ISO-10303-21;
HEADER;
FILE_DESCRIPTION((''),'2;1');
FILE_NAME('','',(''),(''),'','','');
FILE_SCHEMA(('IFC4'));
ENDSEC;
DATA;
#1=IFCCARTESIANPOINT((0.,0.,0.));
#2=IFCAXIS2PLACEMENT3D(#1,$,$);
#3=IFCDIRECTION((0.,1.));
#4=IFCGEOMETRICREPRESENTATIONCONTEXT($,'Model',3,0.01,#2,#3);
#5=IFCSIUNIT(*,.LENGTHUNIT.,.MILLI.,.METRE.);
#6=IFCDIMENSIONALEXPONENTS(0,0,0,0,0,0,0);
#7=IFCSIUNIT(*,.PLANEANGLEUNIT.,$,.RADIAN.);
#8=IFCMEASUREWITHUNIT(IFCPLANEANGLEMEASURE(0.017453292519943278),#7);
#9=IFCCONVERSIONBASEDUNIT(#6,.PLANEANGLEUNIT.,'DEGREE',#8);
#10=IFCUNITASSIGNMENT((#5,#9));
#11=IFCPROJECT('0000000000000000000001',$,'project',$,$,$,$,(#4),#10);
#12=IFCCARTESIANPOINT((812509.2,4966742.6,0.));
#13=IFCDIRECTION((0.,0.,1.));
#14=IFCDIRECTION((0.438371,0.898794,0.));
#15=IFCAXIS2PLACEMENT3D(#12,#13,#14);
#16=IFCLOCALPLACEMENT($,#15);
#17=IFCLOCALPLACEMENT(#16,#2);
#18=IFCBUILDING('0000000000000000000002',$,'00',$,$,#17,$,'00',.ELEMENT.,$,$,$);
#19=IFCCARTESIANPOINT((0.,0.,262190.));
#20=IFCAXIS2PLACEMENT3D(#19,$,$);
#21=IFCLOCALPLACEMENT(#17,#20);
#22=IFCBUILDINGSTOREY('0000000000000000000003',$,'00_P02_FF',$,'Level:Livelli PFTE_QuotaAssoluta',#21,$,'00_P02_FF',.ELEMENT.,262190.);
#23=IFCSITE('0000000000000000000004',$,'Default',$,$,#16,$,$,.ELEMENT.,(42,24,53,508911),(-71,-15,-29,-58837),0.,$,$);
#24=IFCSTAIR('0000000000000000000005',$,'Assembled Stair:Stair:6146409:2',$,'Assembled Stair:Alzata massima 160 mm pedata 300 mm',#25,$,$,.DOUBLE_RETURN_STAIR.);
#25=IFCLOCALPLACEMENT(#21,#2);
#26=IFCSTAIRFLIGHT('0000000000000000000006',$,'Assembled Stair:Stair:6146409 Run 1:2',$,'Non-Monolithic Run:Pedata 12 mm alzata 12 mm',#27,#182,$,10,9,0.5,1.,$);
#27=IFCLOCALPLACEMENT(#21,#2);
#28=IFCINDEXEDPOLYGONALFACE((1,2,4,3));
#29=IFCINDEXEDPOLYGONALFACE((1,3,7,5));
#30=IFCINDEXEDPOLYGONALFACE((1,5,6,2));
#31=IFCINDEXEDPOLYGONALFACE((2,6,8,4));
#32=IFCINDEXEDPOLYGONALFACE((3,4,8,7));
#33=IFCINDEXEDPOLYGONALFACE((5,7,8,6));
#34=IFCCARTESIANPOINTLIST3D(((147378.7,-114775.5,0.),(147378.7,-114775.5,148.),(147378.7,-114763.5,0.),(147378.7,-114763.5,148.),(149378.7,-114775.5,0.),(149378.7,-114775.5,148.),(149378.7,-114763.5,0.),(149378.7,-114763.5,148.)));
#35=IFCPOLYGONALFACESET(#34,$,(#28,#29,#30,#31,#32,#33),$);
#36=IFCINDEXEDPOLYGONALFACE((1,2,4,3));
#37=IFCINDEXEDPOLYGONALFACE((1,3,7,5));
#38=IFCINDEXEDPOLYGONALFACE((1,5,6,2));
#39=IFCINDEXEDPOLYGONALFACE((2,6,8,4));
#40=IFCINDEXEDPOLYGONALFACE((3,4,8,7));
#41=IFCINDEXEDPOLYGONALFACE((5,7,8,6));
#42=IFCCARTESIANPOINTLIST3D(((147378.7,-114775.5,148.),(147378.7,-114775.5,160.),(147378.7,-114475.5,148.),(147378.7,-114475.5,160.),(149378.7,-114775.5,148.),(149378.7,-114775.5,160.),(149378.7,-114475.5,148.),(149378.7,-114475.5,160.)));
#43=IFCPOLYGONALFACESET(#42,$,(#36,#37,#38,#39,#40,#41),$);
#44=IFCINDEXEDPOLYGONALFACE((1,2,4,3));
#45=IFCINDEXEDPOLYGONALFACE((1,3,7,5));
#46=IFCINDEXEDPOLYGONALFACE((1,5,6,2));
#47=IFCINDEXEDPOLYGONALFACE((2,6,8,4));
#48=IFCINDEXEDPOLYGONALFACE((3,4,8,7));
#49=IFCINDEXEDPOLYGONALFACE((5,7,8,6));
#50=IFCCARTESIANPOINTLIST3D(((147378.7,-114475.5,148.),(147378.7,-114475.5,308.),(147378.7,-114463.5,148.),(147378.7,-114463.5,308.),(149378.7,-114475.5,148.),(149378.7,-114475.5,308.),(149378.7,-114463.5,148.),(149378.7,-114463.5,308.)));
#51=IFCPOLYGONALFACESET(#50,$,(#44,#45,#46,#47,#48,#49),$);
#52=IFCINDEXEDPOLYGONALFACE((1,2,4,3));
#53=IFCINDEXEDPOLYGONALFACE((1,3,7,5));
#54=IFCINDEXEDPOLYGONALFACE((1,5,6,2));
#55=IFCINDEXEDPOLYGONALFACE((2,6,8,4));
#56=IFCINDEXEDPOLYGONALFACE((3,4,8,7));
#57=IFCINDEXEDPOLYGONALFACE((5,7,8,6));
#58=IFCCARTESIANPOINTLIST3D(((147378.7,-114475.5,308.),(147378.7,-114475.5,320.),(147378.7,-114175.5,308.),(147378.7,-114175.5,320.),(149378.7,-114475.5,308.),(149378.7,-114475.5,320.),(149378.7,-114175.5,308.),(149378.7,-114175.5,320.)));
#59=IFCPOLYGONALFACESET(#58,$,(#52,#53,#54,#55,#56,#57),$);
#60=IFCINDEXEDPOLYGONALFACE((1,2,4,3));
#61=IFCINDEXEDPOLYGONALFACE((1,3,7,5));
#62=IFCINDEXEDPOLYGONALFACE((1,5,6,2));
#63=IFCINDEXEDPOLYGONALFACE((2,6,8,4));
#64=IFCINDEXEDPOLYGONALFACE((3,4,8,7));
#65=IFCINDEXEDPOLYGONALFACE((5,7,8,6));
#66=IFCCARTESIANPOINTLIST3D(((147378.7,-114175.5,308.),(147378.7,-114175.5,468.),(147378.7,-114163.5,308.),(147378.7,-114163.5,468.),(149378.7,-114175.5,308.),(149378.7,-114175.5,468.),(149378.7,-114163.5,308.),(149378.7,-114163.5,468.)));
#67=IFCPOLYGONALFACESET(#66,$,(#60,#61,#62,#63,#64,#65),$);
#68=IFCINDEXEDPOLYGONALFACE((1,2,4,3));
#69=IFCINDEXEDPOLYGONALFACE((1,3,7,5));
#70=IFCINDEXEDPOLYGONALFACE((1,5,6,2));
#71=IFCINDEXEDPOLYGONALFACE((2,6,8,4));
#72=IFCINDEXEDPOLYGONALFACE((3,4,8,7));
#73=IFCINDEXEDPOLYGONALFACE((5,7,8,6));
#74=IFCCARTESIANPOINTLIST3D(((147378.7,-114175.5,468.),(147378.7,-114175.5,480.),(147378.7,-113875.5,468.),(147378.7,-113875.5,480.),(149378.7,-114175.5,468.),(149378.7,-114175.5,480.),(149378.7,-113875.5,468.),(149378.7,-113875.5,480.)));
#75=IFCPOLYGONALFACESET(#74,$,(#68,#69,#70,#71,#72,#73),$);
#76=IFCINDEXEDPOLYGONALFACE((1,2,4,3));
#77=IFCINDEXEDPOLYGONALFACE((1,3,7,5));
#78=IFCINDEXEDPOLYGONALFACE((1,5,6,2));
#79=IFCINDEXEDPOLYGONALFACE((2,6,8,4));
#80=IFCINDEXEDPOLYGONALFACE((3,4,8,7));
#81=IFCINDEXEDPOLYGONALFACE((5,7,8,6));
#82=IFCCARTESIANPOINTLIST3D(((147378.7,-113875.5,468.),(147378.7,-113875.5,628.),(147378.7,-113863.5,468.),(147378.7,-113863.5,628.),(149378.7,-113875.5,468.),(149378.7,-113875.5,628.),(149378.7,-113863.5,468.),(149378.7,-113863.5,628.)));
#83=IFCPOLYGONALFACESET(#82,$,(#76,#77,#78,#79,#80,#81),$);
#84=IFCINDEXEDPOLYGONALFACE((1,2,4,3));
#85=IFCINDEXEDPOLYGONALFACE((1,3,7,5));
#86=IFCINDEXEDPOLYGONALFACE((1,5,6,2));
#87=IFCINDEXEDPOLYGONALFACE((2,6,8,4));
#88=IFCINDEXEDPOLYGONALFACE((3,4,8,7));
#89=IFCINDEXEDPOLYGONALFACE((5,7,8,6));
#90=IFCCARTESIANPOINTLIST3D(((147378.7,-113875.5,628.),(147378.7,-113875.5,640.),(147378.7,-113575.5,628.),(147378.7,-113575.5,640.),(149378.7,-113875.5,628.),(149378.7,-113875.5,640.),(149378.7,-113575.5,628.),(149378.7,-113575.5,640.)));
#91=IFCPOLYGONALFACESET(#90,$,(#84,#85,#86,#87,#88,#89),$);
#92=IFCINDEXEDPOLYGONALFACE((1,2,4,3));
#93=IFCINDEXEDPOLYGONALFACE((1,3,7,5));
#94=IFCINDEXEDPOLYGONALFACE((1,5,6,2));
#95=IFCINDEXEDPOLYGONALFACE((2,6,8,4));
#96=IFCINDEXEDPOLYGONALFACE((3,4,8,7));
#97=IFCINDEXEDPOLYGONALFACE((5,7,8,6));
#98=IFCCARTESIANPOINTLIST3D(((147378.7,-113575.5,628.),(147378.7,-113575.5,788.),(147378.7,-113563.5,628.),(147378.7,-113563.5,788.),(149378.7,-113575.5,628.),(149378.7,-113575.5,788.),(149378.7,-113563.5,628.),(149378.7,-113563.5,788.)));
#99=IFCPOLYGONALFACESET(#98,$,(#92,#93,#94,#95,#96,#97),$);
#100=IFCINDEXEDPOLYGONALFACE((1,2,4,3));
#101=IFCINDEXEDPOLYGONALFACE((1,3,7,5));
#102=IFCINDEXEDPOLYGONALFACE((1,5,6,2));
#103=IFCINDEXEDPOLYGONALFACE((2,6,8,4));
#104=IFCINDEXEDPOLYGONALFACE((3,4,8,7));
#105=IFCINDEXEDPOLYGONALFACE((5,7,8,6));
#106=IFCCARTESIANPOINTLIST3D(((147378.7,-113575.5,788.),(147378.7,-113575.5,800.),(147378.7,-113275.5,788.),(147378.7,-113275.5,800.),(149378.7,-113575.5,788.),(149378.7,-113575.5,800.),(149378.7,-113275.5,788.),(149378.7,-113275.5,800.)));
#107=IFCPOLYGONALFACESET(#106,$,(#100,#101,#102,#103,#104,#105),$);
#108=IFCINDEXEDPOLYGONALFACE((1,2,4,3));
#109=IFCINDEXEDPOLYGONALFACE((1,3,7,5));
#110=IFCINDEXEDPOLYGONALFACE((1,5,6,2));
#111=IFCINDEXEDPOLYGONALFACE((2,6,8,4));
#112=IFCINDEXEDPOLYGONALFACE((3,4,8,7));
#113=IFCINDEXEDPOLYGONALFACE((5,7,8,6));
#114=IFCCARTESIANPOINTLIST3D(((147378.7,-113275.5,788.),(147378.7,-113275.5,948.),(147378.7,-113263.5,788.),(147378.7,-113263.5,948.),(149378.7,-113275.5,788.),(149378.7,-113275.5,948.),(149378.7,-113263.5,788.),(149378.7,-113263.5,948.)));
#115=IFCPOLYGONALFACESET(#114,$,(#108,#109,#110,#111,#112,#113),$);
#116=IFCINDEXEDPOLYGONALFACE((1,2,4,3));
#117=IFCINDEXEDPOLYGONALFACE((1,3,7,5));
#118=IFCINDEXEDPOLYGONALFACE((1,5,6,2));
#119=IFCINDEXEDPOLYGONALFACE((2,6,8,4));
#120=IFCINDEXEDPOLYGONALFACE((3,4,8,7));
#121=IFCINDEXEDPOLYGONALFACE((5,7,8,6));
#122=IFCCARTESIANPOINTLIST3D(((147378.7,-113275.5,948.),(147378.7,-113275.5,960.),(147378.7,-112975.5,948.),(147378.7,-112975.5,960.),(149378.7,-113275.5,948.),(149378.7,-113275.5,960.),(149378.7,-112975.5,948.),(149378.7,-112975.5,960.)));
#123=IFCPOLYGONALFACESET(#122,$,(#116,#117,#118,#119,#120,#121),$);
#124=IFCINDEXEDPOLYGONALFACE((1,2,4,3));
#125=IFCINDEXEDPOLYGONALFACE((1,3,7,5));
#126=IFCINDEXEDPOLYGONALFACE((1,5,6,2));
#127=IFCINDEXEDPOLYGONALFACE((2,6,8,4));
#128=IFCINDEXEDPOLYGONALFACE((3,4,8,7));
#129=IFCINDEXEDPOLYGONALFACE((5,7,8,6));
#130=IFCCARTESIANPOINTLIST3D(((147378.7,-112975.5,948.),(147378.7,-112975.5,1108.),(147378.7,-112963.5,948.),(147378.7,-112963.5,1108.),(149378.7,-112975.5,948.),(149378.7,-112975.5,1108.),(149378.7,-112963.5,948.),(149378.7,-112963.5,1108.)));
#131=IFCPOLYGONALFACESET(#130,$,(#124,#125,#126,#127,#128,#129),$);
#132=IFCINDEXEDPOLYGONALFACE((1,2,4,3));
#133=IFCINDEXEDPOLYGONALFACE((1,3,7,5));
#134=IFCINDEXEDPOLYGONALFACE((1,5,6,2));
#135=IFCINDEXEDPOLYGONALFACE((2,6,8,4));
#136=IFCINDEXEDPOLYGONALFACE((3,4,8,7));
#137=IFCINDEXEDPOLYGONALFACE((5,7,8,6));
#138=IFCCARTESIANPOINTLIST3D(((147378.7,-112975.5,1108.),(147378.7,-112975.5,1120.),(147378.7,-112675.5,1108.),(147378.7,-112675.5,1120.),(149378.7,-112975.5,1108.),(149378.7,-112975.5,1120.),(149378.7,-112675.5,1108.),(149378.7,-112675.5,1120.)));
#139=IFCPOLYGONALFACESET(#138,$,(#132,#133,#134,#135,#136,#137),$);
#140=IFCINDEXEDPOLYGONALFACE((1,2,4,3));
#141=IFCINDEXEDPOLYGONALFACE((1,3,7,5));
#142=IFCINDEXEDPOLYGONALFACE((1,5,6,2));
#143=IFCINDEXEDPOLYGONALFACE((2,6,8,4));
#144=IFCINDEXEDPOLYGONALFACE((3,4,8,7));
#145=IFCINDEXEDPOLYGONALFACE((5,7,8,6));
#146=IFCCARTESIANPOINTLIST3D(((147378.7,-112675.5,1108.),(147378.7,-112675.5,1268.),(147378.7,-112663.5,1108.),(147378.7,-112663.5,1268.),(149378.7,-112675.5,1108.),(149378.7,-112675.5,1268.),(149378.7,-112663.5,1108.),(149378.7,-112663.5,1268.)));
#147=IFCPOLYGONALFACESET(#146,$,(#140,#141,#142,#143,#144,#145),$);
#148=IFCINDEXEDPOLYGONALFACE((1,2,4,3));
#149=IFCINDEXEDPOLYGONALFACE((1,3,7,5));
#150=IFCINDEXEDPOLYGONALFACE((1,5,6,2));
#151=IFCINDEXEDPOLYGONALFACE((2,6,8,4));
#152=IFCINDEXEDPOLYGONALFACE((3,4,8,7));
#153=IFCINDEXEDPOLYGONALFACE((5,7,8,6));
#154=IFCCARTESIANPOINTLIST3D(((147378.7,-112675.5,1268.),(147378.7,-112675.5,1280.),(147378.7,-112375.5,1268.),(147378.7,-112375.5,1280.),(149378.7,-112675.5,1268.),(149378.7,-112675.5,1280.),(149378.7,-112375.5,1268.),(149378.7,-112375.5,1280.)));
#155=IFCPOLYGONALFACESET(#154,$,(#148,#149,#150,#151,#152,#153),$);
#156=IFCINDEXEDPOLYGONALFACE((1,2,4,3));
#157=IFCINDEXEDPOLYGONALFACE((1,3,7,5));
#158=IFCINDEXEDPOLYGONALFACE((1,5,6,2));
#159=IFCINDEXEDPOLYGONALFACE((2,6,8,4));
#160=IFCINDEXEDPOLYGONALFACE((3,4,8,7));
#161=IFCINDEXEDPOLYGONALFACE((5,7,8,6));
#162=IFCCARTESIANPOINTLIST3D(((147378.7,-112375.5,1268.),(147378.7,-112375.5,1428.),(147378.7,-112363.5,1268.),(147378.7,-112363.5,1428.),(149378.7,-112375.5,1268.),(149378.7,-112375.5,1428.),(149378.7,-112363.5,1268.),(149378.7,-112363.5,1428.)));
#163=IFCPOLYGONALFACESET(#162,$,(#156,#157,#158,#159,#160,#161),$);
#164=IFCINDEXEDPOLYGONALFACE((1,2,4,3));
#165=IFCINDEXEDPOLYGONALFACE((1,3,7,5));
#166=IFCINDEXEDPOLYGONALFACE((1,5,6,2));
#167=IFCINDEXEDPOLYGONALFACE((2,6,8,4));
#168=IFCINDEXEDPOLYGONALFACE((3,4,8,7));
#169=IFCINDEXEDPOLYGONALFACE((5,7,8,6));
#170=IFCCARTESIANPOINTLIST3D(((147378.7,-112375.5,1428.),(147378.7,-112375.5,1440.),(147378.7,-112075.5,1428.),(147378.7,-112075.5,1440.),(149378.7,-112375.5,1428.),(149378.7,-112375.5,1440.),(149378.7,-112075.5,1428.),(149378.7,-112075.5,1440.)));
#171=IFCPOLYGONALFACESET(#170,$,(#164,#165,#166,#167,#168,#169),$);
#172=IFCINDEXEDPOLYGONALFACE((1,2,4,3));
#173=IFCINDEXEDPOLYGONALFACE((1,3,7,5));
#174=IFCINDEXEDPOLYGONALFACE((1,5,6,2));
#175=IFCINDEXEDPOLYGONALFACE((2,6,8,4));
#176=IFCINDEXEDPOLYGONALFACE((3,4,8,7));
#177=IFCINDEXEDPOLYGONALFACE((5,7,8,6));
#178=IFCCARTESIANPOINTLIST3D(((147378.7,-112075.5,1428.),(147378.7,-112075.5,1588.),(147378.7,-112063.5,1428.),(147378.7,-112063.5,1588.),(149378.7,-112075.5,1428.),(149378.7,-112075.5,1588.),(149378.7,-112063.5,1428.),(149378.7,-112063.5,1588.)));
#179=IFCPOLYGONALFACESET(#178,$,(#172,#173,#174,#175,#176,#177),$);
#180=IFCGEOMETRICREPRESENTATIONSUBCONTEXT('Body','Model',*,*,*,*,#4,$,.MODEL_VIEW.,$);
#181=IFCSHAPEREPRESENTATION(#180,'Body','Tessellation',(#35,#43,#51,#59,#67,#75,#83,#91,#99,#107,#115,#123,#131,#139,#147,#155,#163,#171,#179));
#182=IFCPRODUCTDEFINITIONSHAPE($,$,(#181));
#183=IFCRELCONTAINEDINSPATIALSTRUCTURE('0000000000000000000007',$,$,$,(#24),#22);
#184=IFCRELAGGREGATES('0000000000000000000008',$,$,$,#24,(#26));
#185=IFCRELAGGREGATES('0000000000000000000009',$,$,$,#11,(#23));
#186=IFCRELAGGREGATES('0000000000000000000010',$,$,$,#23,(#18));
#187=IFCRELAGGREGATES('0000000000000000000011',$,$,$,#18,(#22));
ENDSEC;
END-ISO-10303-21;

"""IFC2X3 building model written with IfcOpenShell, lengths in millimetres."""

from ifc_helpers import new_model, entity, si_unit, converted_unit, direction, frame, frame_2d, origin, origin_2d_with_axis, place, context, subcontext, project, spatial, rectangle, extrude, element, aggregate, save


model = new_model("IFC2X3")

# Units and contexts
model_context = context("Model", 3, precision=0.01, world=origin(), true_north=direction((0.0, 1.0)))
body_context = subcontext(model_context, "Body", "Model", "MODEL_VIEW")
ifc_project = project(units=[si_unit("LENGTHUNIT", "METRE", prefix="MILLI"), converted_unit("PLANEANGLEUNIT", "DEGREE", entity("IfcPlaneAngleMeasure", 0.017453292519943278), si_unit("PLANEANGLEUNIT", "RADIAN"), dimensions=[0, 0, 0, 0, 0, 0, 0])], contexts=[model_context])

# Site, building, storey
site_placement = place(None, frame((812509.2, 4966742.6, 0.0), z_axis=(0.0, 0.0, 1.0), x_axis=(0.438371, 0.898794, 0.0)))
site = spatial("IfcSite", under=ifc_project, at=site_placement, Name="Default", CompositionType="ELEMENT", RefLatitude=(42, 24, 53, 508911), RefLongitude=(-71, -15, -29, -58837), RefElevation=0.0)
building_placement = place(site_placement, origin())
building = spatial("IfcBuilding", under=site, at=building_placement, Name="00", LongName="00", CompositionType="ELEMENT")
storey_placement = place(building_placement, frame((0.0, 0.0, 262190.0)))
storey = spatial("IfcBuildingStorey", under=building, at=storey_placement, Name="00_P02_FF", ObjectType="Level:Livelli PFTE_QuotaAssoluta", LongName="00_P02_FF", CompositionType="ELEMENT", Elevation=262190.0)

# Stair
stair_1_placement = place(storey_placement, origin())
stair_1 = element("IfcStair", 1, at=stair_1_placement, inside=storey, Name="Assembled Stair:Stair:6146409:2", ObjectType="Assembled Stair:Alzata massima 160 mm pedata 300 mm", ShapeType="DOUBLE_RETURN_STAIR")

# Stair flight
stair_flight_1_placement = place(stair_1_placement, origin())
stair_flight_1 = element("IfcStairFlight", 2, at=stair_flight_1_placement, Name="Assembled Stair:Stair:6146409 Run 1:2", ObjectType="Non-Monolithic Run:Pedata 12 mm alzata 12 mm", NumberOfRiser=10, NumberOfTreads=9, RiserHeight=0.5, TreadLength=1.0, context=body_context, shape_type="SweptSolid", body=[
    extrude(rectangle(XDim=2000.0, YDim=12.0, at=origin_2d_with_axis()), frame((148378.7, -114769.5, 0.0), z_axis=(0.0, 0.0, 1.0), x_axis=(-1.0, 0.0, 0.0)), (0.0, 0.0, 1.0), 148.0),
    extrude(rectangle(XDim=300.0, YDim=2000.0, at=frame_2d((0.0, 0.0), x_axis=(1.0, 0.0))), frame((148378.7, -114625.5, 148.0), z_axis=(0.0, 0.0, 1.0), x_axis=(0.0, -1.0, 0.0)), (0.0, 0.0, 1.0), 12.0),
    extrude(rectangle(XDim=2000.0, YDim=12.0, at=frame_2d((0.0, 0.0), x_axis=(1.0, 0.0))), frame((148378.7, -114469.5, 148.0), z_axis=(0.0, 0.0, 1.0), x_axis=(-1.0, 0.0, 0.0)), (0.0, 0.0, 1.0), 160.0),
    extrude(rectangle(XDim=300.0, YDim=2000.0, at=frame_2d((0.0, 0.0), x_axis=(1.0, 0.0))), frame((148378.7, -114325.5, 308.0), z_axis=(0.0, 0.0, 1.0), x_axis=(0.0, -1.0, 0.0)), (0.0, 0.0, 1.0), 12.0),
    extrude(rectangle(XDim=2000.0, YDim=12.0, at=frame_2d((0.0, 0.0), x_axis=(1.0, 0.0))), frame((148378.7, -114169.5, 308.0), z_axis=(0.0, 0.0, 1.0), x_axis=(-1.0, 0.0, 0.0)), (0.0, 0.0, 1.0), 160.0),
    extrude(rectangle(XDim=300.0, YDim=2000.0, at=frame_2d((0.0, 0.0), x_axis=(1.0, 0.0))), frame((148378.7, -114025.5, 468.0), z_axis=(0.0, 0.0, 1.0), x_axis=(0.0, -1.0, 0.0)), (0.0, 0.0, 1.0), 12.0),
    extrude(rectangle(XDim=2000.0, YDim=12.0, at=frame_2d((0.0, 0.0), x_axis=(1.0, 0.0))), frame((148378.7, -113869.5, 468.0), z_axis=(0.0, 0.0, 1.0), x_axis=(-1.0, 0.0, 0.0)), (0.0, 0.0, 1.0), 160.0),
    extrude(rectangle(XDim=300.0, YDim=2000.0, at=frame_2d((0.0, 0.0), x_axis=(1.0, 0.0))), frame((148378.7, -113725.5, 628.0), z_axis=(0.0, 0.0, 1.0), x_axis=(0.0, -1.0, 0.0)), (0.0, 0.0, 1.0), 12.0),
    extrude(rectangle(XDim=2000.0, YDim=12.0, at=frame_2d((0.0, 0.0), x_axis=(1.0, 0.0))), frame((148378.7, -113569.5, 628.0), z_axis=(0.0, 0.0, 1.0), x_axis=(-1.0, 0.0, 0.0)), (0.0, 0.0, 1.0), 160.0),
    extrude(rectangle(XDim=300.0, YDim=2000.0, at=frame_2d((0.0, 0.0), x_axis=(1.0, 0.0))), frame((148378.7, -113425.5, 788.0), z_axis=(0.0, 0.0, 1.0), x_axis=(0.0, -1.0, 0.0)), (0.0, 0.0, 1.0), 12.0),
    extrude(rectangle(XDim=2000.0, YDim=12.0, at=frame_2d((0.0, 0.0), x_axis=(1.0, 0.0))), frame((148378.7, -113269.5, 788.0), z_axis=(0.0, 0.0, 1.0), x_axis=(-1.0, 0.0, 0.0)), (0.0, 0.0, 1.0), 160.0),
    extrude(rectangle(XDim=300.0, YDim=2000.0, at=frame_2d((0.0, 0.0), x_axis=(1.0, 0.0))), frame((148378.7, -113125.5, 948.0), z_axis=(0.0, 0.0, 1.0), x_axis=(0.0, -1.0, 0.0)), (0.0, 0.0, 1.0), 12.0),
    extrude(rectangle(XDim=2000.0, YDim=12.0, at=frame_2d((0.0, 0.0), x_axis=(1.0, 0.0))), frame((148378.7, -112969.5, 948.0), z_axis=(0.0, 0.0, 1.0), x_axis=(-1.0, 0.0, 0.0)), (0.0, 0.0, 1.0), 160.0),
    extrude(rectangle(XDim=300.0, YDim=2000.0, at=frame_2d((0.0, 0.0), x_axis=(1.0, 0.0))), frame((148378.7, -112825.5, 1108.0), z_axis=(0.0, 0.0, 1.0), x_axis=(0.0, -1.0, 0.0)), (0.0, 0.0, 1.0), 12.0),
    extrude(rectangle(XDim=2000.0, YDim=12.0, at=frame_2d((0.0, 0.0), x_axis=(1.0, 0.0))), frame((148378.7, -112669.5, 1108.0), z_axis=(0.0, 0.0, 1.0), x_axis=(-1.0, 0.0, 0.0)), (0.0, 0.0, 1.0), 160.0),
    extrude(rectangle(XDim=300.0, YDim=2000.0, at=frame_2d((0.0, 0.0), x_axis=(1.0, 0.0))), frame((148378.7, -112525.5, 1268.0), z_axis=(0.0, 0.0, 1.0), x_axis=(0.0, -1.0, 0.0)), (0.0, 0.0, 1.0), 12.0),
    extrude(rectangle(XDim=2000.0, YDim=12.0, at=frame_2d((0.0, 0.0), x_axis=(1.0, 0.0))), frame((148378.7, -112369.5, 1268.0), z_axis=(0.0, 0.0, 1.0), x_axis=(-1.0, 0.0, 0.0)), (0.0, 0.0, 1.0), 160.0),
    extrude(rectangle(XDim=300.0, YDim=2000.0, at=frame_2d((0.0, 0.0), x_axis=(1.0, 0.0))), frame((148378.7, -112225.5, 1428.0), z_axis=(0.0, 0.0, 1.0), x_axis=(0.0, -1.0, 0.0)), (0.0, 0.0, 1.0), 12.0),
    extrude(rectangle(XDim=2000.0, YDim=12.0, at=origin_2d_with_axis()), frame((148378.7, -112069.5, 1428.0), z_axis=(0.0, 0.0, 1.0), x_axis=(-1.0, 0.0, 0.0)), (0.0, 0.0, 1.0), 160.0),
])
aggregate(stair_1, [stair_flight_1])

save(model, "model.ifc")
